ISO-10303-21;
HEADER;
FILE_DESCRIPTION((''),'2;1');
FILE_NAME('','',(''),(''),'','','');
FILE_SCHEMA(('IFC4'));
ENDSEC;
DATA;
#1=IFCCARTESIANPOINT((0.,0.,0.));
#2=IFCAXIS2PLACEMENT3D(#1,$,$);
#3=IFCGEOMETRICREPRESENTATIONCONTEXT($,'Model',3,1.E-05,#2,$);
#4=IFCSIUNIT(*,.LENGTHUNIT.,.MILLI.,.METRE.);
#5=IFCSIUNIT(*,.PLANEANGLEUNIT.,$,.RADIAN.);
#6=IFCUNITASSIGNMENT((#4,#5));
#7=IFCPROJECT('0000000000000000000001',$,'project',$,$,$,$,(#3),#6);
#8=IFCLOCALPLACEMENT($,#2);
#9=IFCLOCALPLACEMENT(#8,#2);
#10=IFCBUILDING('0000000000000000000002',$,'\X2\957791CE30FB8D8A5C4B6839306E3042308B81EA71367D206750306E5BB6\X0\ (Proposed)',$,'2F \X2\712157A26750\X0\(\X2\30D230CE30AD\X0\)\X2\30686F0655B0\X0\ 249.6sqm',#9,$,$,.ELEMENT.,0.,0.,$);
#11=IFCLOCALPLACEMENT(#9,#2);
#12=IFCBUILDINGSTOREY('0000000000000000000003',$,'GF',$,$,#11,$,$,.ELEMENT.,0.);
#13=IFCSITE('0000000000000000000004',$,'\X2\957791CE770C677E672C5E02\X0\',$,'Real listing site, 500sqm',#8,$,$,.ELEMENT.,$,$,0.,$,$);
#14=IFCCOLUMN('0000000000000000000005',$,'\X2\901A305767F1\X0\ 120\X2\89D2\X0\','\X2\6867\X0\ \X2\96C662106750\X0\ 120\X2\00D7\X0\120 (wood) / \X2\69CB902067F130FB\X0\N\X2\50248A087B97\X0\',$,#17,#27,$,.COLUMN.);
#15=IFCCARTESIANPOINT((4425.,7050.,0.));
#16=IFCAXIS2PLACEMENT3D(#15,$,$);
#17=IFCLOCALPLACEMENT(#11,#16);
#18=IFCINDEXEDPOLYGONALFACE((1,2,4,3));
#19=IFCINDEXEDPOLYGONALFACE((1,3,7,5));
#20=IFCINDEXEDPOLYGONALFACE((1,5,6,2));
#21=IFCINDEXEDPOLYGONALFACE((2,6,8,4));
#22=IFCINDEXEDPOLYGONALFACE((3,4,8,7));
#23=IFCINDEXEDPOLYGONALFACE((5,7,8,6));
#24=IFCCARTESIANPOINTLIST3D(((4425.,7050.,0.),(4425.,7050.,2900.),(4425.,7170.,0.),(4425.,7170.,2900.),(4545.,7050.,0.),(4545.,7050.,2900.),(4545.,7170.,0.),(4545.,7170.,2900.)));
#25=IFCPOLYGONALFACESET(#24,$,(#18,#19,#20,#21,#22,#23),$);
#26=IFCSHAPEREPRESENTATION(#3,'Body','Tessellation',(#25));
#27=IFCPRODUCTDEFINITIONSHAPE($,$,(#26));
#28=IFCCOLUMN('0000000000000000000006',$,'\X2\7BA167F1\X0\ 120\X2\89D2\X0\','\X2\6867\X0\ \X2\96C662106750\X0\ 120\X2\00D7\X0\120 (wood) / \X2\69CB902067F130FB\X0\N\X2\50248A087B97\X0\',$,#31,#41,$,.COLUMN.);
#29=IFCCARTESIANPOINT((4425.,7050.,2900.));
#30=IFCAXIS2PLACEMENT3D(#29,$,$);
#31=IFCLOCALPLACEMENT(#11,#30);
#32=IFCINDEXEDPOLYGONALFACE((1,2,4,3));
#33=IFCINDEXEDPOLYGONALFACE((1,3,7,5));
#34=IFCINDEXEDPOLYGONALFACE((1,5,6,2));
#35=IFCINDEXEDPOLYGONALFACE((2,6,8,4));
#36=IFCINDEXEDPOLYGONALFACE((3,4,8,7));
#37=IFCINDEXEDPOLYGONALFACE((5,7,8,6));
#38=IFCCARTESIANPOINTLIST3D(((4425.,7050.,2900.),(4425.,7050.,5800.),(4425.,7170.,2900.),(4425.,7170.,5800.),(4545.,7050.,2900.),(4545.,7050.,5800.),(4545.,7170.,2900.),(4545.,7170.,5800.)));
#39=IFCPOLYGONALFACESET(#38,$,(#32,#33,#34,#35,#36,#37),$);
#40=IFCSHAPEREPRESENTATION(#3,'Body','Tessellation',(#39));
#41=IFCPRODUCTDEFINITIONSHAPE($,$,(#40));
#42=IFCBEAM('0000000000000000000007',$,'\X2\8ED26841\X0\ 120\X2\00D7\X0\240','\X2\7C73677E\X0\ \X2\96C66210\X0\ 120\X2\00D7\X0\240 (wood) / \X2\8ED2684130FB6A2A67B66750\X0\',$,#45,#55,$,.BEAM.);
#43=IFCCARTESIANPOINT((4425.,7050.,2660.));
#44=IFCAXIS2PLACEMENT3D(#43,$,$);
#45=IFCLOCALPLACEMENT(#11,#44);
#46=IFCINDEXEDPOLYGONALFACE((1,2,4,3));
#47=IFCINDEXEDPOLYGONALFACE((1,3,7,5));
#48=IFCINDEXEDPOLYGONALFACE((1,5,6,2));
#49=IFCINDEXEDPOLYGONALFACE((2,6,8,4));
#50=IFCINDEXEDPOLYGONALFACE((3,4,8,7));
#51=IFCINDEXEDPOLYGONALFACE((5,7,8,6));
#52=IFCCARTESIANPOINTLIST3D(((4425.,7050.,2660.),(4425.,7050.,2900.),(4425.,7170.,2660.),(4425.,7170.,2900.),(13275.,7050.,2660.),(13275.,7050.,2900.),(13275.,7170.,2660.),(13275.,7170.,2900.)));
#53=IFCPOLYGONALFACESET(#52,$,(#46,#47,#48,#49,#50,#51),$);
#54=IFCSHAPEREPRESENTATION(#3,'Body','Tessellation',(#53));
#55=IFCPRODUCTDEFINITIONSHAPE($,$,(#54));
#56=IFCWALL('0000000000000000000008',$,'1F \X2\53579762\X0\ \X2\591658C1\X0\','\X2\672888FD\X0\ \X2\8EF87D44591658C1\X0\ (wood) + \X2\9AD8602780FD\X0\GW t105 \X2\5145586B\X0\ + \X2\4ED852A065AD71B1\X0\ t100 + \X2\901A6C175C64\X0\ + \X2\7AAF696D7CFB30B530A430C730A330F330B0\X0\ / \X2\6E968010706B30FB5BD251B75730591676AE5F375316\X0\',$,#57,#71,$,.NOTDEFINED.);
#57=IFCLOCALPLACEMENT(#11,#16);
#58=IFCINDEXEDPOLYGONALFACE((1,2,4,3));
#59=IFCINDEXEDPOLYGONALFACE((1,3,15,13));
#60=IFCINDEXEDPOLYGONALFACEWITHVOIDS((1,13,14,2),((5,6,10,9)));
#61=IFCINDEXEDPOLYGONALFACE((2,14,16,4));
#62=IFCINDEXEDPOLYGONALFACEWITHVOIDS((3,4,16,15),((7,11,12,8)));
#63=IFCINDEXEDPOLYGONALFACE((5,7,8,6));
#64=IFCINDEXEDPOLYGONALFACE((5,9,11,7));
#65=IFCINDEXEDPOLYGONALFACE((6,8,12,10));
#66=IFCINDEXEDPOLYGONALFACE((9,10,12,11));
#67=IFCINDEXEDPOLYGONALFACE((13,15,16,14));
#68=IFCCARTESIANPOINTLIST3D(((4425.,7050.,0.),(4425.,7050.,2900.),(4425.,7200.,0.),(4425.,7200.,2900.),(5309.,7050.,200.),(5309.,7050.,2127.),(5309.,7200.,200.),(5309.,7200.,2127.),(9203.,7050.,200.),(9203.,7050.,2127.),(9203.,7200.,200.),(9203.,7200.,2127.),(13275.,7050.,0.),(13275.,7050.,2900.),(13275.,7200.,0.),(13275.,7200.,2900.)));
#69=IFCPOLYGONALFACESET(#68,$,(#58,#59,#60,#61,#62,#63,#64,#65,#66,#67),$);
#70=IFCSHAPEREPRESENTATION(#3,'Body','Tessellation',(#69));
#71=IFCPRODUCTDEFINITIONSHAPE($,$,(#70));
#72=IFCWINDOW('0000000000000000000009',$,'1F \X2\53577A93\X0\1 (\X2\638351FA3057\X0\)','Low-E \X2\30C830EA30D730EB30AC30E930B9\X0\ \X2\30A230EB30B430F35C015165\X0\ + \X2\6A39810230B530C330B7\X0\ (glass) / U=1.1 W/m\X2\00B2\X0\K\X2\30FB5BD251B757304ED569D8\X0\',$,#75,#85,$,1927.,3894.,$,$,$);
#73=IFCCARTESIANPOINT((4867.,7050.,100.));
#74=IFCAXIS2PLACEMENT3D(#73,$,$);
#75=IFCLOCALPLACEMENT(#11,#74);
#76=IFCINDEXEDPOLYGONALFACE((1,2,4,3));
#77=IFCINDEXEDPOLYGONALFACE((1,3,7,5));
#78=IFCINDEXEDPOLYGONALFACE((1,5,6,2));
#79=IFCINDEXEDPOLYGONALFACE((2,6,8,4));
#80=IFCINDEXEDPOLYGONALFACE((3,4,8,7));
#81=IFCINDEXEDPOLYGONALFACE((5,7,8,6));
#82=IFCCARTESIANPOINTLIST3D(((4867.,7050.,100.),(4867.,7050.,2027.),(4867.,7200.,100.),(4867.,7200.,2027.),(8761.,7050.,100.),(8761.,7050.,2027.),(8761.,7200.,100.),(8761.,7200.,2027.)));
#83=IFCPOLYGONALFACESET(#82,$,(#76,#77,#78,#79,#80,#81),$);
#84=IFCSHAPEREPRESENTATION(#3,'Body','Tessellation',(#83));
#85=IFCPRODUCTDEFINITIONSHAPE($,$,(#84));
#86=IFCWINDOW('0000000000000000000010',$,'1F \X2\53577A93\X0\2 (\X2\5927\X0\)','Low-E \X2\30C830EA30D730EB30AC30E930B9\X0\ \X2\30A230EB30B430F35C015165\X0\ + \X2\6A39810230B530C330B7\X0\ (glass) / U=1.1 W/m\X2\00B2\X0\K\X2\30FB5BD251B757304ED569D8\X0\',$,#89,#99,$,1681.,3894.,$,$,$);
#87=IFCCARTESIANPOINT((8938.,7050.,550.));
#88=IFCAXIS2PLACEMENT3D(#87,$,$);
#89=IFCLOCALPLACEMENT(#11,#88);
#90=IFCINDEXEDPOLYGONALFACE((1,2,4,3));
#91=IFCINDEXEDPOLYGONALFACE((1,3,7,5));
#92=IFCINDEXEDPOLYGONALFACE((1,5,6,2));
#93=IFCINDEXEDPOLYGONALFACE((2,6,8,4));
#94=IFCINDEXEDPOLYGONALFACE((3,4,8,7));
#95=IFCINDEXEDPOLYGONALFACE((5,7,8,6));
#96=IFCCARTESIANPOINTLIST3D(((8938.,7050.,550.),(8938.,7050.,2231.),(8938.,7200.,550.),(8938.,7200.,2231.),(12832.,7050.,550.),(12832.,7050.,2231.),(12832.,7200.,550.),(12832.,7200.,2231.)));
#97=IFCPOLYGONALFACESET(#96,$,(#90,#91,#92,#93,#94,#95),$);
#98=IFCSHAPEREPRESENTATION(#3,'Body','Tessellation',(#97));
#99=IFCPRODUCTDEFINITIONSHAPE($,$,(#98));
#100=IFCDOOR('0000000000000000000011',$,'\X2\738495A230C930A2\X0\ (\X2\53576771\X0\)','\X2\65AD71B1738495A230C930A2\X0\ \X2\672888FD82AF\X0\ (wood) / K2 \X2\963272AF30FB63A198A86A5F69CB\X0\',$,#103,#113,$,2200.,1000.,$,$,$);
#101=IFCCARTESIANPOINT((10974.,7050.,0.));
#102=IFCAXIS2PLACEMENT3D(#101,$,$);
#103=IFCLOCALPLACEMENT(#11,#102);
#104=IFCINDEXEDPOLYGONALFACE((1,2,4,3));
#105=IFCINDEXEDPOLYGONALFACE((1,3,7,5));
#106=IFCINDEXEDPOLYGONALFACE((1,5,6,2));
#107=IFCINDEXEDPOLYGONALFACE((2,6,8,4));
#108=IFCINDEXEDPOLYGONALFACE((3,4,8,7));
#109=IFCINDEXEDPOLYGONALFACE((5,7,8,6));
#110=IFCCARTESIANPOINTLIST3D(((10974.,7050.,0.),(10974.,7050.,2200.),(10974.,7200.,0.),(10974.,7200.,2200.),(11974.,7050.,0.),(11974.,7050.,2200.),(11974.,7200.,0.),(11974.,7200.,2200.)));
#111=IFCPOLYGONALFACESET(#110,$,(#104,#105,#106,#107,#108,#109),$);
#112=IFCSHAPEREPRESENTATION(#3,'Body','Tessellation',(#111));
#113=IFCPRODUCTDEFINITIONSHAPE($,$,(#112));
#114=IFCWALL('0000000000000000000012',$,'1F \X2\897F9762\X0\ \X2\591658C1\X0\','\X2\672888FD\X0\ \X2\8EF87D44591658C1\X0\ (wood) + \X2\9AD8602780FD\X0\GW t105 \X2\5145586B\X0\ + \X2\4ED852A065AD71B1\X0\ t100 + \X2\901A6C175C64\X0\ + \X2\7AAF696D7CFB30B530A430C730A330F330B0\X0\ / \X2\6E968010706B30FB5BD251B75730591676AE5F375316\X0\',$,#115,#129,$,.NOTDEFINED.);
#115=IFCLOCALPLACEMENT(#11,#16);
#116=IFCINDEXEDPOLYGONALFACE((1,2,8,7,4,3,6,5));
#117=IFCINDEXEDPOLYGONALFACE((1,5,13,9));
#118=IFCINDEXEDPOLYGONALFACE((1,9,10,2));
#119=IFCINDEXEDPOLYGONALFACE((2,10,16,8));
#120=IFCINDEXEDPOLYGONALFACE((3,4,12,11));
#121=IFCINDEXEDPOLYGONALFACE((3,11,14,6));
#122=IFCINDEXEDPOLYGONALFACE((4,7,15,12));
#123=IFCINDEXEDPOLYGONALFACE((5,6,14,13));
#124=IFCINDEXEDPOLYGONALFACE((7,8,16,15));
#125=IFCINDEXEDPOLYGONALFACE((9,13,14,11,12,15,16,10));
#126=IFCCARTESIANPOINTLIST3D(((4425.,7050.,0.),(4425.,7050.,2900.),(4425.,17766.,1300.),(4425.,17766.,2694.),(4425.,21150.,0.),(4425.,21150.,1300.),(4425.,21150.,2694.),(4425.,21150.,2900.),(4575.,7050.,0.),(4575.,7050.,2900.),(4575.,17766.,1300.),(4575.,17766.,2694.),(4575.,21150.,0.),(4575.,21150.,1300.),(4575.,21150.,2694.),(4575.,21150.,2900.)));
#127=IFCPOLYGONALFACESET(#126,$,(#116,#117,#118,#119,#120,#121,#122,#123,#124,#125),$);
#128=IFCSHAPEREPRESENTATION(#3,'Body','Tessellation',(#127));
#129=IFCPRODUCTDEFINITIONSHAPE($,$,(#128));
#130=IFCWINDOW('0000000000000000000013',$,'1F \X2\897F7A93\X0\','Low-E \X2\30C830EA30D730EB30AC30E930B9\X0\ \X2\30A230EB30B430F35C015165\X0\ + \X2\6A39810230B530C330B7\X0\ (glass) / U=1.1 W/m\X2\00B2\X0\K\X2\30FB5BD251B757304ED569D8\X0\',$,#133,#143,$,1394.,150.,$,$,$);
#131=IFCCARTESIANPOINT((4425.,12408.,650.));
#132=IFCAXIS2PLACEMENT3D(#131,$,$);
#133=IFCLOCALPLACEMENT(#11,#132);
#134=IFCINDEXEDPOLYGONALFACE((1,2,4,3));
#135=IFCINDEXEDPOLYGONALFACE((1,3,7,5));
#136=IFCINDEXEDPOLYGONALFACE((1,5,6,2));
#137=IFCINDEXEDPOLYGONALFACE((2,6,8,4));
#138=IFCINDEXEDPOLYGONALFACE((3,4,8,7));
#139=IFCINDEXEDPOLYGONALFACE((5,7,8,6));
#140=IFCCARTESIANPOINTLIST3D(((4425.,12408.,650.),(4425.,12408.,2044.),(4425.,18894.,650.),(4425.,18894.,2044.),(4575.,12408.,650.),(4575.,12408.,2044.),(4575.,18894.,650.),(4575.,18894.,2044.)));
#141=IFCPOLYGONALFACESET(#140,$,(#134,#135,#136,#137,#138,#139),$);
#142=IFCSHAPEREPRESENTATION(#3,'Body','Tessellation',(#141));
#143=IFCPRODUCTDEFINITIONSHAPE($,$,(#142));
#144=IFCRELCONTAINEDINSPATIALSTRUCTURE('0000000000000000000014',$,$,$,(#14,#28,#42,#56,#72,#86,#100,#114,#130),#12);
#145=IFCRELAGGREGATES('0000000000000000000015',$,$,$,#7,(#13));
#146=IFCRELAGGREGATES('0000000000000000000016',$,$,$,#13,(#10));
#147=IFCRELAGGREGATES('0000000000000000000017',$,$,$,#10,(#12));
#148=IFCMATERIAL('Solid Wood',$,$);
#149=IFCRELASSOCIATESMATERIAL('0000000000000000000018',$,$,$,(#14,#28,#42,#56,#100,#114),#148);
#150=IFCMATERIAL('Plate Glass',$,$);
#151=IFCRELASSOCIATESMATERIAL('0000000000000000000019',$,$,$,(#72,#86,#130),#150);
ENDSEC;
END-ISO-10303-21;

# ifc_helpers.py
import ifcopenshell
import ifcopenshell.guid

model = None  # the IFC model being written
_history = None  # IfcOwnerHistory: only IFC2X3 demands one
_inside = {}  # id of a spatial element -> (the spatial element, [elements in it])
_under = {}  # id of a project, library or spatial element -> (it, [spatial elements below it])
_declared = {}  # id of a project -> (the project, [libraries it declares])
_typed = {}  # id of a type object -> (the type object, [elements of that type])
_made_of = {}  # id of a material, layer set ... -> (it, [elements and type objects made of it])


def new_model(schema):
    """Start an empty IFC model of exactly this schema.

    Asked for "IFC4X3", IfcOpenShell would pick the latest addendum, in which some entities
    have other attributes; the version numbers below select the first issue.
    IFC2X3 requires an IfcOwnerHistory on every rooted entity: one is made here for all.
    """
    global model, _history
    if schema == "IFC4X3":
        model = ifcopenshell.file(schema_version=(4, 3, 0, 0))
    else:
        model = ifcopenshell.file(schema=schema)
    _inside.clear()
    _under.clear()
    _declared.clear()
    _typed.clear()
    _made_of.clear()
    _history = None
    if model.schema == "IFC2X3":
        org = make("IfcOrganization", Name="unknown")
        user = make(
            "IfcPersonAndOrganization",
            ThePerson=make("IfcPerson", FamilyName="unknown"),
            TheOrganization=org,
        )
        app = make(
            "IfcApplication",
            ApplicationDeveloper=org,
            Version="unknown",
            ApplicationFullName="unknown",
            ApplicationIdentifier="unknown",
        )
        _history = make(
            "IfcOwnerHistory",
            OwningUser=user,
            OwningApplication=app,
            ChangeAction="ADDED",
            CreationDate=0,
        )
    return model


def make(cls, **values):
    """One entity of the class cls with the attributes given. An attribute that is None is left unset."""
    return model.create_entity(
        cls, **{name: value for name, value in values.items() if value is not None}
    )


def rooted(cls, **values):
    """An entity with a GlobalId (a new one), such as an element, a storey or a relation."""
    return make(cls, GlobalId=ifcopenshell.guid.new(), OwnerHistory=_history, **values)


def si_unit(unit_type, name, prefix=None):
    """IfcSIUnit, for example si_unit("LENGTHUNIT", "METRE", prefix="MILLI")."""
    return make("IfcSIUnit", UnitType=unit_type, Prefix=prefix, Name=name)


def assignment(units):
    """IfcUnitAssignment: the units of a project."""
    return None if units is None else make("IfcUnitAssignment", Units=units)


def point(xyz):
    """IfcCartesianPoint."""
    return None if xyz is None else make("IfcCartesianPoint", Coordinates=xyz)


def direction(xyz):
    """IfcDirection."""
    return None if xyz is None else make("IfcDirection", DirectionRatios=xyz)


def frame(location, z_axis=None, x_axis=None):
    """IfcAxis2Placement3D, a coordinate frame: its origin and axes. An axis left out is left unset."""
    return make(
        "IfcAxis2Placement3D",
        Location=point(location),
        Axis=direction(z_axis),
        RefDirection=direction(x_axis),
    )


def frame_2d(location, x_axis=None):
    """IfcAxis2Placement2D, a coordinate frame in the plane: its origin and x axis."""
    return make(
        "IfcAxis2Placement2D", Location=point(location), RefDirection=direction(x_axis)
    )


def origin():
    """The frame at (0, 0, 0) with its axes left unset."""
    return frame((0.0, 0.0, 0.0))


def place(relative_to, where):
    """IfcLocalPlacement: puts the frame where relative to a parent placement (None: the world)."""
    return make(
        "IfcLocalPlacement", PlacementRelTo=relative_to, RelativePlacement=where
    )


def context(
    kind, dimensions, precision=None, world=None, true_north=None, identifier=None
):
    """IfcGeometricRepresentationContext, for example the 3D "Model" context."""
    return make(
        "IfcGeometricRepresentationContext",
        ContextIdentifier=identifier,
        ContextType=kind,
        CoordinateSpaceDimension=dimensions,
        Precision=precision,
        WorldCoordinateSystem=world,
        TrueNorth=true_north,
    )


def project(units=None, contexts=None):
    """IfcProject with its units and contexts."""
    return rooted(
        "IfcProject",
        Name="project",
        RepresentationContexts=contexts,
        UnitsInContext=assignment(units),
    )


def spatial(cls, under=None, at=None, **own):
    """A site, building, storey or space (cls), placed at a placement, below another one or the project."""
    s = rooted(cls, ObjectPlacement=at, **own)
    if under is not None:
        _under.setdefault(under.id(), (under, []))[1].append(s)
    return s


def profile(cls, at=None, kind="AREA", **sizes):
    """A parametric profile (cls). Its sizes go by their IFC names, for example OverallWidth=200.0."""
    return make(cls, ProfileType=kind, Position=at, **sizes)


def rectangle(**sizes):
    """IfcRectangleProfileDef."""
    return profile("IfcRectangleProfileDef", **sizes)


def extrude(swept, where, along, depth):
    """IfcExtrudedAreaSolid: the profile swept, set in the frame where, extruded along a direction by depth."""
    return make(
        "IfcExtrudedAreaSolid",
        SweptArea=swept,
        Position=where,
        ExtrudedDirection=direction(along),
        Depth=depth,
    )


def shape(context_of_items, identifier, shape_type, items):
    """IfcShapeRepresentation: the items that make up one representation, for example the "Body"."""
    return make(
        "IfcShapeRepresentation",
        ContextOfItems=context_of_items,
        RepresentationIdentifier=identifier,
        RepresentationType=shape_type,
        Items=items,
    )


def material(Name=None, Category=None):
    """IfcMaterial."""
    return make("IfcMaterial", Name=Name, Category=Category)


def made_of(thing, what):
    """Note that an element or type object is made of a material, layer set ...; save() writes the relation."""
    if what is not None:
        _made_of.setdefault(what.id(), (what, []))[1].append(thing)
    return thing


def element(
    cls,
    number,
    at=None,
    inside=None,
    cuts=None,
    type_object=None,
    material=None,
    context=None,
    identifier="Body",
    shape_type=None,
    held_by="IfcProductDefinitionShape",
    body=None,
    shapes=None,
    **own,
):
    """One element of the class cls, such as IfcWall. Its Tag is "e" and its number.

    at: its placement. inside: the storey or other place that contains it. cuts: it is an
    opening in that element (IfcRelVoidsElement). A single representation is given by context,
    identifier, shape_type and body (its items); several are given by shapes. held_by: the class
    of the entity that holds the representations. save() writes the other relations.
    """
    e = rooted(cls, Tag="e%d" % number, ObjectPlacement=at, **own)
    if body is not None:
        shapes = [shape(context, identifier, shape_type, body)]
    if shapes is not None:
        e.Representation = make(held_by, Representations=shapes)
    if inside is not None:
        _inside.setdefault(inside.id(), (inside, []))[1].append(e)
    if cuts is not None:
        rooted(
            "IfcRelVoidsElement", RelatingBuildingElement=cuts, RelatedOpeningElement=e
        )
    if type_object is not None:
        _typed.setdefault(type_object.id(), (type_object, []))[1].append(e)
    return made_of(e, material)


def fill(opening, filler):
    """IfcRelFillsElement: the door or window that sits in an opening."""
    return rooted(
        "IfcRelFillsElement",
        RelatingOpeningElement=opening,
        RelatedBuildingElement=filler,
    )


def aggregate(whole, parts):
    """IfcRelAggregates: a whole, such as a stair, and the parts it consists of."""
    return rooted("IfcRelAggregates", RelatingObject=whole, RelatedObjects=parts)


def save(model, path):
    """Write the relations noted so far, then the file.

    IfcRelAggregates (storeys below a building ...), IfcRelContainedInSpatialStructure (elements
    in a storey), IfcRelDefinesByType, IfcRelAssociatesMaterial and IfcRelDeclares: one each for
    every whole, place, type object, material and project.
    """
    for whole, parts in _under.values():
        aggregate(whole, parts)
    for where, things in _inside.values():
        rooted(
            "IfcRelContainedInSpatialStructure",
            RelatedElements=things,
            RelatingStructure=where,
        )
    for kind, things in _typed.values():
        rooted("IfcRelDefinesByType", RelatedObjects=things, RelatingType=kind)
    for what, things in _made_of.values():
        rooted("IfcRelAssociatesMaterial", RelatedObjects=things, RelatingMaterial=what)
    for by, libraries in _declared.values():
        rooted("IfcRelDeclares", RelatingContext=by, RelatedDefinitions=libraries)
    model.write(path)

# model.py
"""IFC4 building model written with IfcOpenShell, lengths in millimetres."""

from ifc_helpers import new_model, si_unit, frame, frame_2d, origin, place, context, project, spatial, rectangle, extrude, material, element, fill, save


model = new_model("IFC4")

# Units and contexts
model_context = context("Model", 3, precision=1e-05, world=origin())
ifc_project = project(units=[si_unit("LENGTHUNIT", "METRE", prefix="MILLI"), si_unit("PLANEANGLEUNIT", "RADIAN")], contexts=[model_context])

# Site, building, storey
site_placement = place(None, origin())
site = spatial("IfcSite", under=ifc_project, at=site_placement, Name="長野県松本市", ObjectType="Real listing site, 500sqm", CompositionType="ELEMENT", RefElevation=0.0)
building_placement = place(site_placement, origin())
building = spatial("IfcBuilding", under=site, at=building_placement, Name="長野・越屋根のある自然素材の家 (Proposed)", ObjectType="2F 無垢材(ヒノキ)と漆喰 249.6sqm", CompositionType="ELEMENT", ElevationOfRefHeight=0.0, ElevationOfTerrain=0.0)
storey_placement = place(building_placement, origin())
storey = spatial("IfcBuildingStorey", under=building, at=storey_placement, Name="GF", CompositionType="ELEMENT", Elevation=0.0)

# Columns
ifc_material_1 = material(Name="Solid Wood")
column_1_placement = place(storey_placement, frame((4425.0, 7050.0, 0.0)))
element("IfcColumn", 1, at=column_1_placement, inside=storey, material=ifc_material_1, Name="通し柱 120角", Description="桧 集成材 120×120 (wood) / 構造柱・N値計算", PredefinedType="COLUMN", context=model_context, shape_type="SweptSolid", body=[
    extrude(rectangle(XDim=120.0, YDim=120.0, at=frame_2d((60.0, 60.0))), frame((4425.0, 7050.0, 0.0)), (0.0, 0.0, 1.0), 2900.0),
])
column_2_placement = place(storey_placement, frame((4425.0, 7050.0, 2900.0)))
element("IfcColumn", 2, at=column_2_placement, inside=storey, material=ifc_material_1, Name="管柱 120角", Description="桧 集成材 120×120 (wood) / 構造柱・N値計算", PredefinedType="COLUMN", context=model_context, shape_type="SweptSolid", body=[
    extrude(rectangle(XDim=120.0, YDim=120.0, at=frame_2d((60.0, 60.0))), frame((4425.0, 7050.0, 2900.0)), (0.0, 0.0, 1.0), 2900.0),
])

# Beam
beam_1_placement = place(storey_placement, frame((4425.0, 7050.0, 2660.0)))
element("IfcBeam", 3, at=beam_1_placement, inside=storey, material=ifc_material_1, Name="軒桁 120×240", Description="米松 集成 120×240 (wood) / 軒桁・横架材", PredefinedType="BEAM", context=model_context, shape_type="SweptSolid", body=[
    extrude(rectangle(XDim=8850.0, YDim=120.0, at=frame_2d((4425.0, 60.0))), frame((4425.0, 7050.0, 2660.0)), (0.0, 0.0, 1.0), 240.0),
])

# Wall, openings, windows, door
wall_1_placement = place(storey_placement, frame((4425.0, 7050.0, 0.0)))
wall_1 = element("IfcWall", 4, at=wall_1_placement, inside=storey, material=ifc_material_1, Name="1F 南面 外壁", Description="木製 軸組外壁 (wood) + 高性能GW t105 充填 + 付加断熱 t100 + 通気層 + 窯業系サイディング / 準耐火・寒冷地外皮強化", PredefinedType="NOTDEFINED", context=model_context, shape_type="SweptSolid", body=[
    extrude(rectangle(XDim=8850.0, YDim=150.0, at=frame_2d((4425.0, 75.0))), frame((4425.0, 7050.0, 0.0)), (0.0, 0.0, 1.0), 2900.0),
])
opening_1_placement = place(storey_placement, frame((4867.0, 7050.0, 100.0)))
opening_1 = element("IfcOpeningElement", 5, at=opening_1_placement, cuts=wall_1, PredefinedType="NOTDEFINED", context=model_context, shape_type="SweptSolid", body=[
    extrude(rectangle(XDim=3894.0, YDim=150.0, at=frame_2d((1947.0, 75.0))), frame((4867.0, 7050.0, 100.0)), (0.0, 0.0, 1.0), 1927.0),
])
opening_2_placement = place(storey_placement, frame((8938.0, 7050.0, 550.0)))
opening_2 = element("IfcOpeningElement", 6, at=opening_2_placement, cuts=wall_1, PredefinedType="NOTDEFINED", context=model_context, shape_type="SweptSolid", body=[
    extrude(rectangle(XDim=3894.0, YDim=150.0, at=frame_2d((1947.0, 75.0))), frame((8938.0, 7050.0, 550.0)), (0.0, 0.0, 1.0), 1681.0),
])
opening_3_placement = place(storey_placement, frame((10974.0, 7050.0, 0.0)))
opening_3 = element("IfcOpeningElement", 7, at=opening_3_placement, cuts=wall_1, PredefinedType="NOTDEFINED", context=model_context, shape_type="SweptSolid", body=[
    extrude(rectangle(XDim=1000.0, YDim=150.0, at=frame_2d((500.0, 75.0))), frame((10974.0, 7050.0, 0.0)), (0.0, 0.0, 1.0), 2200.0),
])
ifc_material_2 = material(Name="Plate Glass")
window_1_placement = place(storey_placement, frame((4867.0, 7050.0, 100.0)))
window_1 = element("IfcWindow", 8, at=window_1_placement, inside=storey, material=ifc_material_2, Name="1F 南窓1 (掃出し)", Description="Low-E トリプルガラス アルゴン封入 + 樹脂サッシ (glass) / U=1.1 W/m²K・寒冷地仕様", OverallHeight=1927.0, OverallWidth=3894.0, context=model_context, shape_type="SweptSolid", body=[
    extrude(rectangle(XDim=3894.0, YDim=150.0, at=frame_2d((1947.0, 75.0))), frame((4867.0, 7050.0, 100.0)), (0.0, 0.0, 1.0), 1927.0),
])
fill(opening_1, window_1)
window_2_placement = place(storey_placement, frame((8938.0, 7050.0, 550.0)))
window_2 = element("IfcWindow", 9, at=window_2_placement, inside=storey, material=ifc_material_2, Name="1F 南窓2 (大)", Description="Low-E トリプルガラス アルゴン封入 + 樹脂サッシ (glass) / U=1.1 W/m²K・寒冷地仕様", OverallHeight=1681.0, OverallWidth=3894.0, context=model_context, shape_type="SweptSolid", body=[
    extrude(rectangle(XDim=3894.0, YDim=150.0, at=frame_2d((1947.0, 75.0))), frame((8938.0, 7050.0, 550.0)), (0.0, 0.0, 1.0), 1681.0),
])
fill(opening_2, window_2)
door_placement = place(storey_placement, frame((10974.0, 7050.0, 0.0)))
door = element("IfcDoor", 10, at=door_placement, inside=storey, material=ifc_material_1, Name="玄関ドア (南東)", Description="断熱玄関ドア 木製芯 (wood) / K2 防犯・採風機構", OverallHeight=2200.0, OverallWidth=1000.0, context=model_context, shape_type="SweptSolid", body=[
    extrude(rectangle(XDim=1000.0, YDim=150.0, at=frame_2d((500.0, 75.0))), frame((10974.0, 7050.0, 0.0)), (0.0, 0.0, 1.0), 2200.0),
])
fill(opening_3, door)

# Wall, opening, window
wall_2_placement = place(storey_placement, frame((4425.0, 7050.0, 0.0)))
wall_2 = element("IfcWall", 11, at=wall_2_placement, inside=storey, material=ifc_material_1, Name="1F 西面 外壁", Description="木製 軸組外壁 (wood) + 高性能GW t105 充填 + 付加断熱 t100 + 通気層 + 窯業系サイディング / 準耐火・寒冷地外皮強化", PredefinedType="NOTDEFINED", context=model_context, shape_type="SweptSolid", body=[
    extrude(rectangle(XDim=150.0, YDim=14100.0, at=frame_2d((75.0, 7050.0))), frame((4425.0, 7050.0, 0.0)), (0.0, 0.0, 1.0), 2900.0),
])
opening_4_placement = place(storey_placement, frame((4425.0, 12408.0, 650.0)))
opening_4 = element("IfcOpeningElement", 12, at=opening_4_placement, cuts=wall_2, PredefinedType="NOTDEFINED", context=model_context, shape_type="SweptSolid", body=[
    extrude(rectangle(XDim=150.0, YDim=6486.0, at=frame_2d((75.0, 3243.0))), frame((4425.0, 12408.0, 650.0)), (0.0, 0.0, 1.0), 1394.0),
])
window_3_placement = place(storey_placement, frame((4425.0, 12408.0, 650.0)))
window_3 = element("IfcWindow", 13, at=window_3_placement, inside=storey, material=ifc_material_2, Name="1F 西窓", Description="Low-E トリプルガラス アルゴン封入 + 樹脂サッシ (glass) / U=1.1 W/m²K・寒冷地仕様", OverallHeight=1394.0, OverallWidth=150.0, context=model_context, shape_type="SweptSolid", body=[
    extrude(rectangle(XDim=150.0, YDim=6486.0, at=frame_2d((75.0, 3243.0))), frame((4425.0, 12408.0, 650.0)), (0.0, 0.0, 1.0), 1394.0),
])
fill(opening_4, window_3)

save(model, "model.ifc")
